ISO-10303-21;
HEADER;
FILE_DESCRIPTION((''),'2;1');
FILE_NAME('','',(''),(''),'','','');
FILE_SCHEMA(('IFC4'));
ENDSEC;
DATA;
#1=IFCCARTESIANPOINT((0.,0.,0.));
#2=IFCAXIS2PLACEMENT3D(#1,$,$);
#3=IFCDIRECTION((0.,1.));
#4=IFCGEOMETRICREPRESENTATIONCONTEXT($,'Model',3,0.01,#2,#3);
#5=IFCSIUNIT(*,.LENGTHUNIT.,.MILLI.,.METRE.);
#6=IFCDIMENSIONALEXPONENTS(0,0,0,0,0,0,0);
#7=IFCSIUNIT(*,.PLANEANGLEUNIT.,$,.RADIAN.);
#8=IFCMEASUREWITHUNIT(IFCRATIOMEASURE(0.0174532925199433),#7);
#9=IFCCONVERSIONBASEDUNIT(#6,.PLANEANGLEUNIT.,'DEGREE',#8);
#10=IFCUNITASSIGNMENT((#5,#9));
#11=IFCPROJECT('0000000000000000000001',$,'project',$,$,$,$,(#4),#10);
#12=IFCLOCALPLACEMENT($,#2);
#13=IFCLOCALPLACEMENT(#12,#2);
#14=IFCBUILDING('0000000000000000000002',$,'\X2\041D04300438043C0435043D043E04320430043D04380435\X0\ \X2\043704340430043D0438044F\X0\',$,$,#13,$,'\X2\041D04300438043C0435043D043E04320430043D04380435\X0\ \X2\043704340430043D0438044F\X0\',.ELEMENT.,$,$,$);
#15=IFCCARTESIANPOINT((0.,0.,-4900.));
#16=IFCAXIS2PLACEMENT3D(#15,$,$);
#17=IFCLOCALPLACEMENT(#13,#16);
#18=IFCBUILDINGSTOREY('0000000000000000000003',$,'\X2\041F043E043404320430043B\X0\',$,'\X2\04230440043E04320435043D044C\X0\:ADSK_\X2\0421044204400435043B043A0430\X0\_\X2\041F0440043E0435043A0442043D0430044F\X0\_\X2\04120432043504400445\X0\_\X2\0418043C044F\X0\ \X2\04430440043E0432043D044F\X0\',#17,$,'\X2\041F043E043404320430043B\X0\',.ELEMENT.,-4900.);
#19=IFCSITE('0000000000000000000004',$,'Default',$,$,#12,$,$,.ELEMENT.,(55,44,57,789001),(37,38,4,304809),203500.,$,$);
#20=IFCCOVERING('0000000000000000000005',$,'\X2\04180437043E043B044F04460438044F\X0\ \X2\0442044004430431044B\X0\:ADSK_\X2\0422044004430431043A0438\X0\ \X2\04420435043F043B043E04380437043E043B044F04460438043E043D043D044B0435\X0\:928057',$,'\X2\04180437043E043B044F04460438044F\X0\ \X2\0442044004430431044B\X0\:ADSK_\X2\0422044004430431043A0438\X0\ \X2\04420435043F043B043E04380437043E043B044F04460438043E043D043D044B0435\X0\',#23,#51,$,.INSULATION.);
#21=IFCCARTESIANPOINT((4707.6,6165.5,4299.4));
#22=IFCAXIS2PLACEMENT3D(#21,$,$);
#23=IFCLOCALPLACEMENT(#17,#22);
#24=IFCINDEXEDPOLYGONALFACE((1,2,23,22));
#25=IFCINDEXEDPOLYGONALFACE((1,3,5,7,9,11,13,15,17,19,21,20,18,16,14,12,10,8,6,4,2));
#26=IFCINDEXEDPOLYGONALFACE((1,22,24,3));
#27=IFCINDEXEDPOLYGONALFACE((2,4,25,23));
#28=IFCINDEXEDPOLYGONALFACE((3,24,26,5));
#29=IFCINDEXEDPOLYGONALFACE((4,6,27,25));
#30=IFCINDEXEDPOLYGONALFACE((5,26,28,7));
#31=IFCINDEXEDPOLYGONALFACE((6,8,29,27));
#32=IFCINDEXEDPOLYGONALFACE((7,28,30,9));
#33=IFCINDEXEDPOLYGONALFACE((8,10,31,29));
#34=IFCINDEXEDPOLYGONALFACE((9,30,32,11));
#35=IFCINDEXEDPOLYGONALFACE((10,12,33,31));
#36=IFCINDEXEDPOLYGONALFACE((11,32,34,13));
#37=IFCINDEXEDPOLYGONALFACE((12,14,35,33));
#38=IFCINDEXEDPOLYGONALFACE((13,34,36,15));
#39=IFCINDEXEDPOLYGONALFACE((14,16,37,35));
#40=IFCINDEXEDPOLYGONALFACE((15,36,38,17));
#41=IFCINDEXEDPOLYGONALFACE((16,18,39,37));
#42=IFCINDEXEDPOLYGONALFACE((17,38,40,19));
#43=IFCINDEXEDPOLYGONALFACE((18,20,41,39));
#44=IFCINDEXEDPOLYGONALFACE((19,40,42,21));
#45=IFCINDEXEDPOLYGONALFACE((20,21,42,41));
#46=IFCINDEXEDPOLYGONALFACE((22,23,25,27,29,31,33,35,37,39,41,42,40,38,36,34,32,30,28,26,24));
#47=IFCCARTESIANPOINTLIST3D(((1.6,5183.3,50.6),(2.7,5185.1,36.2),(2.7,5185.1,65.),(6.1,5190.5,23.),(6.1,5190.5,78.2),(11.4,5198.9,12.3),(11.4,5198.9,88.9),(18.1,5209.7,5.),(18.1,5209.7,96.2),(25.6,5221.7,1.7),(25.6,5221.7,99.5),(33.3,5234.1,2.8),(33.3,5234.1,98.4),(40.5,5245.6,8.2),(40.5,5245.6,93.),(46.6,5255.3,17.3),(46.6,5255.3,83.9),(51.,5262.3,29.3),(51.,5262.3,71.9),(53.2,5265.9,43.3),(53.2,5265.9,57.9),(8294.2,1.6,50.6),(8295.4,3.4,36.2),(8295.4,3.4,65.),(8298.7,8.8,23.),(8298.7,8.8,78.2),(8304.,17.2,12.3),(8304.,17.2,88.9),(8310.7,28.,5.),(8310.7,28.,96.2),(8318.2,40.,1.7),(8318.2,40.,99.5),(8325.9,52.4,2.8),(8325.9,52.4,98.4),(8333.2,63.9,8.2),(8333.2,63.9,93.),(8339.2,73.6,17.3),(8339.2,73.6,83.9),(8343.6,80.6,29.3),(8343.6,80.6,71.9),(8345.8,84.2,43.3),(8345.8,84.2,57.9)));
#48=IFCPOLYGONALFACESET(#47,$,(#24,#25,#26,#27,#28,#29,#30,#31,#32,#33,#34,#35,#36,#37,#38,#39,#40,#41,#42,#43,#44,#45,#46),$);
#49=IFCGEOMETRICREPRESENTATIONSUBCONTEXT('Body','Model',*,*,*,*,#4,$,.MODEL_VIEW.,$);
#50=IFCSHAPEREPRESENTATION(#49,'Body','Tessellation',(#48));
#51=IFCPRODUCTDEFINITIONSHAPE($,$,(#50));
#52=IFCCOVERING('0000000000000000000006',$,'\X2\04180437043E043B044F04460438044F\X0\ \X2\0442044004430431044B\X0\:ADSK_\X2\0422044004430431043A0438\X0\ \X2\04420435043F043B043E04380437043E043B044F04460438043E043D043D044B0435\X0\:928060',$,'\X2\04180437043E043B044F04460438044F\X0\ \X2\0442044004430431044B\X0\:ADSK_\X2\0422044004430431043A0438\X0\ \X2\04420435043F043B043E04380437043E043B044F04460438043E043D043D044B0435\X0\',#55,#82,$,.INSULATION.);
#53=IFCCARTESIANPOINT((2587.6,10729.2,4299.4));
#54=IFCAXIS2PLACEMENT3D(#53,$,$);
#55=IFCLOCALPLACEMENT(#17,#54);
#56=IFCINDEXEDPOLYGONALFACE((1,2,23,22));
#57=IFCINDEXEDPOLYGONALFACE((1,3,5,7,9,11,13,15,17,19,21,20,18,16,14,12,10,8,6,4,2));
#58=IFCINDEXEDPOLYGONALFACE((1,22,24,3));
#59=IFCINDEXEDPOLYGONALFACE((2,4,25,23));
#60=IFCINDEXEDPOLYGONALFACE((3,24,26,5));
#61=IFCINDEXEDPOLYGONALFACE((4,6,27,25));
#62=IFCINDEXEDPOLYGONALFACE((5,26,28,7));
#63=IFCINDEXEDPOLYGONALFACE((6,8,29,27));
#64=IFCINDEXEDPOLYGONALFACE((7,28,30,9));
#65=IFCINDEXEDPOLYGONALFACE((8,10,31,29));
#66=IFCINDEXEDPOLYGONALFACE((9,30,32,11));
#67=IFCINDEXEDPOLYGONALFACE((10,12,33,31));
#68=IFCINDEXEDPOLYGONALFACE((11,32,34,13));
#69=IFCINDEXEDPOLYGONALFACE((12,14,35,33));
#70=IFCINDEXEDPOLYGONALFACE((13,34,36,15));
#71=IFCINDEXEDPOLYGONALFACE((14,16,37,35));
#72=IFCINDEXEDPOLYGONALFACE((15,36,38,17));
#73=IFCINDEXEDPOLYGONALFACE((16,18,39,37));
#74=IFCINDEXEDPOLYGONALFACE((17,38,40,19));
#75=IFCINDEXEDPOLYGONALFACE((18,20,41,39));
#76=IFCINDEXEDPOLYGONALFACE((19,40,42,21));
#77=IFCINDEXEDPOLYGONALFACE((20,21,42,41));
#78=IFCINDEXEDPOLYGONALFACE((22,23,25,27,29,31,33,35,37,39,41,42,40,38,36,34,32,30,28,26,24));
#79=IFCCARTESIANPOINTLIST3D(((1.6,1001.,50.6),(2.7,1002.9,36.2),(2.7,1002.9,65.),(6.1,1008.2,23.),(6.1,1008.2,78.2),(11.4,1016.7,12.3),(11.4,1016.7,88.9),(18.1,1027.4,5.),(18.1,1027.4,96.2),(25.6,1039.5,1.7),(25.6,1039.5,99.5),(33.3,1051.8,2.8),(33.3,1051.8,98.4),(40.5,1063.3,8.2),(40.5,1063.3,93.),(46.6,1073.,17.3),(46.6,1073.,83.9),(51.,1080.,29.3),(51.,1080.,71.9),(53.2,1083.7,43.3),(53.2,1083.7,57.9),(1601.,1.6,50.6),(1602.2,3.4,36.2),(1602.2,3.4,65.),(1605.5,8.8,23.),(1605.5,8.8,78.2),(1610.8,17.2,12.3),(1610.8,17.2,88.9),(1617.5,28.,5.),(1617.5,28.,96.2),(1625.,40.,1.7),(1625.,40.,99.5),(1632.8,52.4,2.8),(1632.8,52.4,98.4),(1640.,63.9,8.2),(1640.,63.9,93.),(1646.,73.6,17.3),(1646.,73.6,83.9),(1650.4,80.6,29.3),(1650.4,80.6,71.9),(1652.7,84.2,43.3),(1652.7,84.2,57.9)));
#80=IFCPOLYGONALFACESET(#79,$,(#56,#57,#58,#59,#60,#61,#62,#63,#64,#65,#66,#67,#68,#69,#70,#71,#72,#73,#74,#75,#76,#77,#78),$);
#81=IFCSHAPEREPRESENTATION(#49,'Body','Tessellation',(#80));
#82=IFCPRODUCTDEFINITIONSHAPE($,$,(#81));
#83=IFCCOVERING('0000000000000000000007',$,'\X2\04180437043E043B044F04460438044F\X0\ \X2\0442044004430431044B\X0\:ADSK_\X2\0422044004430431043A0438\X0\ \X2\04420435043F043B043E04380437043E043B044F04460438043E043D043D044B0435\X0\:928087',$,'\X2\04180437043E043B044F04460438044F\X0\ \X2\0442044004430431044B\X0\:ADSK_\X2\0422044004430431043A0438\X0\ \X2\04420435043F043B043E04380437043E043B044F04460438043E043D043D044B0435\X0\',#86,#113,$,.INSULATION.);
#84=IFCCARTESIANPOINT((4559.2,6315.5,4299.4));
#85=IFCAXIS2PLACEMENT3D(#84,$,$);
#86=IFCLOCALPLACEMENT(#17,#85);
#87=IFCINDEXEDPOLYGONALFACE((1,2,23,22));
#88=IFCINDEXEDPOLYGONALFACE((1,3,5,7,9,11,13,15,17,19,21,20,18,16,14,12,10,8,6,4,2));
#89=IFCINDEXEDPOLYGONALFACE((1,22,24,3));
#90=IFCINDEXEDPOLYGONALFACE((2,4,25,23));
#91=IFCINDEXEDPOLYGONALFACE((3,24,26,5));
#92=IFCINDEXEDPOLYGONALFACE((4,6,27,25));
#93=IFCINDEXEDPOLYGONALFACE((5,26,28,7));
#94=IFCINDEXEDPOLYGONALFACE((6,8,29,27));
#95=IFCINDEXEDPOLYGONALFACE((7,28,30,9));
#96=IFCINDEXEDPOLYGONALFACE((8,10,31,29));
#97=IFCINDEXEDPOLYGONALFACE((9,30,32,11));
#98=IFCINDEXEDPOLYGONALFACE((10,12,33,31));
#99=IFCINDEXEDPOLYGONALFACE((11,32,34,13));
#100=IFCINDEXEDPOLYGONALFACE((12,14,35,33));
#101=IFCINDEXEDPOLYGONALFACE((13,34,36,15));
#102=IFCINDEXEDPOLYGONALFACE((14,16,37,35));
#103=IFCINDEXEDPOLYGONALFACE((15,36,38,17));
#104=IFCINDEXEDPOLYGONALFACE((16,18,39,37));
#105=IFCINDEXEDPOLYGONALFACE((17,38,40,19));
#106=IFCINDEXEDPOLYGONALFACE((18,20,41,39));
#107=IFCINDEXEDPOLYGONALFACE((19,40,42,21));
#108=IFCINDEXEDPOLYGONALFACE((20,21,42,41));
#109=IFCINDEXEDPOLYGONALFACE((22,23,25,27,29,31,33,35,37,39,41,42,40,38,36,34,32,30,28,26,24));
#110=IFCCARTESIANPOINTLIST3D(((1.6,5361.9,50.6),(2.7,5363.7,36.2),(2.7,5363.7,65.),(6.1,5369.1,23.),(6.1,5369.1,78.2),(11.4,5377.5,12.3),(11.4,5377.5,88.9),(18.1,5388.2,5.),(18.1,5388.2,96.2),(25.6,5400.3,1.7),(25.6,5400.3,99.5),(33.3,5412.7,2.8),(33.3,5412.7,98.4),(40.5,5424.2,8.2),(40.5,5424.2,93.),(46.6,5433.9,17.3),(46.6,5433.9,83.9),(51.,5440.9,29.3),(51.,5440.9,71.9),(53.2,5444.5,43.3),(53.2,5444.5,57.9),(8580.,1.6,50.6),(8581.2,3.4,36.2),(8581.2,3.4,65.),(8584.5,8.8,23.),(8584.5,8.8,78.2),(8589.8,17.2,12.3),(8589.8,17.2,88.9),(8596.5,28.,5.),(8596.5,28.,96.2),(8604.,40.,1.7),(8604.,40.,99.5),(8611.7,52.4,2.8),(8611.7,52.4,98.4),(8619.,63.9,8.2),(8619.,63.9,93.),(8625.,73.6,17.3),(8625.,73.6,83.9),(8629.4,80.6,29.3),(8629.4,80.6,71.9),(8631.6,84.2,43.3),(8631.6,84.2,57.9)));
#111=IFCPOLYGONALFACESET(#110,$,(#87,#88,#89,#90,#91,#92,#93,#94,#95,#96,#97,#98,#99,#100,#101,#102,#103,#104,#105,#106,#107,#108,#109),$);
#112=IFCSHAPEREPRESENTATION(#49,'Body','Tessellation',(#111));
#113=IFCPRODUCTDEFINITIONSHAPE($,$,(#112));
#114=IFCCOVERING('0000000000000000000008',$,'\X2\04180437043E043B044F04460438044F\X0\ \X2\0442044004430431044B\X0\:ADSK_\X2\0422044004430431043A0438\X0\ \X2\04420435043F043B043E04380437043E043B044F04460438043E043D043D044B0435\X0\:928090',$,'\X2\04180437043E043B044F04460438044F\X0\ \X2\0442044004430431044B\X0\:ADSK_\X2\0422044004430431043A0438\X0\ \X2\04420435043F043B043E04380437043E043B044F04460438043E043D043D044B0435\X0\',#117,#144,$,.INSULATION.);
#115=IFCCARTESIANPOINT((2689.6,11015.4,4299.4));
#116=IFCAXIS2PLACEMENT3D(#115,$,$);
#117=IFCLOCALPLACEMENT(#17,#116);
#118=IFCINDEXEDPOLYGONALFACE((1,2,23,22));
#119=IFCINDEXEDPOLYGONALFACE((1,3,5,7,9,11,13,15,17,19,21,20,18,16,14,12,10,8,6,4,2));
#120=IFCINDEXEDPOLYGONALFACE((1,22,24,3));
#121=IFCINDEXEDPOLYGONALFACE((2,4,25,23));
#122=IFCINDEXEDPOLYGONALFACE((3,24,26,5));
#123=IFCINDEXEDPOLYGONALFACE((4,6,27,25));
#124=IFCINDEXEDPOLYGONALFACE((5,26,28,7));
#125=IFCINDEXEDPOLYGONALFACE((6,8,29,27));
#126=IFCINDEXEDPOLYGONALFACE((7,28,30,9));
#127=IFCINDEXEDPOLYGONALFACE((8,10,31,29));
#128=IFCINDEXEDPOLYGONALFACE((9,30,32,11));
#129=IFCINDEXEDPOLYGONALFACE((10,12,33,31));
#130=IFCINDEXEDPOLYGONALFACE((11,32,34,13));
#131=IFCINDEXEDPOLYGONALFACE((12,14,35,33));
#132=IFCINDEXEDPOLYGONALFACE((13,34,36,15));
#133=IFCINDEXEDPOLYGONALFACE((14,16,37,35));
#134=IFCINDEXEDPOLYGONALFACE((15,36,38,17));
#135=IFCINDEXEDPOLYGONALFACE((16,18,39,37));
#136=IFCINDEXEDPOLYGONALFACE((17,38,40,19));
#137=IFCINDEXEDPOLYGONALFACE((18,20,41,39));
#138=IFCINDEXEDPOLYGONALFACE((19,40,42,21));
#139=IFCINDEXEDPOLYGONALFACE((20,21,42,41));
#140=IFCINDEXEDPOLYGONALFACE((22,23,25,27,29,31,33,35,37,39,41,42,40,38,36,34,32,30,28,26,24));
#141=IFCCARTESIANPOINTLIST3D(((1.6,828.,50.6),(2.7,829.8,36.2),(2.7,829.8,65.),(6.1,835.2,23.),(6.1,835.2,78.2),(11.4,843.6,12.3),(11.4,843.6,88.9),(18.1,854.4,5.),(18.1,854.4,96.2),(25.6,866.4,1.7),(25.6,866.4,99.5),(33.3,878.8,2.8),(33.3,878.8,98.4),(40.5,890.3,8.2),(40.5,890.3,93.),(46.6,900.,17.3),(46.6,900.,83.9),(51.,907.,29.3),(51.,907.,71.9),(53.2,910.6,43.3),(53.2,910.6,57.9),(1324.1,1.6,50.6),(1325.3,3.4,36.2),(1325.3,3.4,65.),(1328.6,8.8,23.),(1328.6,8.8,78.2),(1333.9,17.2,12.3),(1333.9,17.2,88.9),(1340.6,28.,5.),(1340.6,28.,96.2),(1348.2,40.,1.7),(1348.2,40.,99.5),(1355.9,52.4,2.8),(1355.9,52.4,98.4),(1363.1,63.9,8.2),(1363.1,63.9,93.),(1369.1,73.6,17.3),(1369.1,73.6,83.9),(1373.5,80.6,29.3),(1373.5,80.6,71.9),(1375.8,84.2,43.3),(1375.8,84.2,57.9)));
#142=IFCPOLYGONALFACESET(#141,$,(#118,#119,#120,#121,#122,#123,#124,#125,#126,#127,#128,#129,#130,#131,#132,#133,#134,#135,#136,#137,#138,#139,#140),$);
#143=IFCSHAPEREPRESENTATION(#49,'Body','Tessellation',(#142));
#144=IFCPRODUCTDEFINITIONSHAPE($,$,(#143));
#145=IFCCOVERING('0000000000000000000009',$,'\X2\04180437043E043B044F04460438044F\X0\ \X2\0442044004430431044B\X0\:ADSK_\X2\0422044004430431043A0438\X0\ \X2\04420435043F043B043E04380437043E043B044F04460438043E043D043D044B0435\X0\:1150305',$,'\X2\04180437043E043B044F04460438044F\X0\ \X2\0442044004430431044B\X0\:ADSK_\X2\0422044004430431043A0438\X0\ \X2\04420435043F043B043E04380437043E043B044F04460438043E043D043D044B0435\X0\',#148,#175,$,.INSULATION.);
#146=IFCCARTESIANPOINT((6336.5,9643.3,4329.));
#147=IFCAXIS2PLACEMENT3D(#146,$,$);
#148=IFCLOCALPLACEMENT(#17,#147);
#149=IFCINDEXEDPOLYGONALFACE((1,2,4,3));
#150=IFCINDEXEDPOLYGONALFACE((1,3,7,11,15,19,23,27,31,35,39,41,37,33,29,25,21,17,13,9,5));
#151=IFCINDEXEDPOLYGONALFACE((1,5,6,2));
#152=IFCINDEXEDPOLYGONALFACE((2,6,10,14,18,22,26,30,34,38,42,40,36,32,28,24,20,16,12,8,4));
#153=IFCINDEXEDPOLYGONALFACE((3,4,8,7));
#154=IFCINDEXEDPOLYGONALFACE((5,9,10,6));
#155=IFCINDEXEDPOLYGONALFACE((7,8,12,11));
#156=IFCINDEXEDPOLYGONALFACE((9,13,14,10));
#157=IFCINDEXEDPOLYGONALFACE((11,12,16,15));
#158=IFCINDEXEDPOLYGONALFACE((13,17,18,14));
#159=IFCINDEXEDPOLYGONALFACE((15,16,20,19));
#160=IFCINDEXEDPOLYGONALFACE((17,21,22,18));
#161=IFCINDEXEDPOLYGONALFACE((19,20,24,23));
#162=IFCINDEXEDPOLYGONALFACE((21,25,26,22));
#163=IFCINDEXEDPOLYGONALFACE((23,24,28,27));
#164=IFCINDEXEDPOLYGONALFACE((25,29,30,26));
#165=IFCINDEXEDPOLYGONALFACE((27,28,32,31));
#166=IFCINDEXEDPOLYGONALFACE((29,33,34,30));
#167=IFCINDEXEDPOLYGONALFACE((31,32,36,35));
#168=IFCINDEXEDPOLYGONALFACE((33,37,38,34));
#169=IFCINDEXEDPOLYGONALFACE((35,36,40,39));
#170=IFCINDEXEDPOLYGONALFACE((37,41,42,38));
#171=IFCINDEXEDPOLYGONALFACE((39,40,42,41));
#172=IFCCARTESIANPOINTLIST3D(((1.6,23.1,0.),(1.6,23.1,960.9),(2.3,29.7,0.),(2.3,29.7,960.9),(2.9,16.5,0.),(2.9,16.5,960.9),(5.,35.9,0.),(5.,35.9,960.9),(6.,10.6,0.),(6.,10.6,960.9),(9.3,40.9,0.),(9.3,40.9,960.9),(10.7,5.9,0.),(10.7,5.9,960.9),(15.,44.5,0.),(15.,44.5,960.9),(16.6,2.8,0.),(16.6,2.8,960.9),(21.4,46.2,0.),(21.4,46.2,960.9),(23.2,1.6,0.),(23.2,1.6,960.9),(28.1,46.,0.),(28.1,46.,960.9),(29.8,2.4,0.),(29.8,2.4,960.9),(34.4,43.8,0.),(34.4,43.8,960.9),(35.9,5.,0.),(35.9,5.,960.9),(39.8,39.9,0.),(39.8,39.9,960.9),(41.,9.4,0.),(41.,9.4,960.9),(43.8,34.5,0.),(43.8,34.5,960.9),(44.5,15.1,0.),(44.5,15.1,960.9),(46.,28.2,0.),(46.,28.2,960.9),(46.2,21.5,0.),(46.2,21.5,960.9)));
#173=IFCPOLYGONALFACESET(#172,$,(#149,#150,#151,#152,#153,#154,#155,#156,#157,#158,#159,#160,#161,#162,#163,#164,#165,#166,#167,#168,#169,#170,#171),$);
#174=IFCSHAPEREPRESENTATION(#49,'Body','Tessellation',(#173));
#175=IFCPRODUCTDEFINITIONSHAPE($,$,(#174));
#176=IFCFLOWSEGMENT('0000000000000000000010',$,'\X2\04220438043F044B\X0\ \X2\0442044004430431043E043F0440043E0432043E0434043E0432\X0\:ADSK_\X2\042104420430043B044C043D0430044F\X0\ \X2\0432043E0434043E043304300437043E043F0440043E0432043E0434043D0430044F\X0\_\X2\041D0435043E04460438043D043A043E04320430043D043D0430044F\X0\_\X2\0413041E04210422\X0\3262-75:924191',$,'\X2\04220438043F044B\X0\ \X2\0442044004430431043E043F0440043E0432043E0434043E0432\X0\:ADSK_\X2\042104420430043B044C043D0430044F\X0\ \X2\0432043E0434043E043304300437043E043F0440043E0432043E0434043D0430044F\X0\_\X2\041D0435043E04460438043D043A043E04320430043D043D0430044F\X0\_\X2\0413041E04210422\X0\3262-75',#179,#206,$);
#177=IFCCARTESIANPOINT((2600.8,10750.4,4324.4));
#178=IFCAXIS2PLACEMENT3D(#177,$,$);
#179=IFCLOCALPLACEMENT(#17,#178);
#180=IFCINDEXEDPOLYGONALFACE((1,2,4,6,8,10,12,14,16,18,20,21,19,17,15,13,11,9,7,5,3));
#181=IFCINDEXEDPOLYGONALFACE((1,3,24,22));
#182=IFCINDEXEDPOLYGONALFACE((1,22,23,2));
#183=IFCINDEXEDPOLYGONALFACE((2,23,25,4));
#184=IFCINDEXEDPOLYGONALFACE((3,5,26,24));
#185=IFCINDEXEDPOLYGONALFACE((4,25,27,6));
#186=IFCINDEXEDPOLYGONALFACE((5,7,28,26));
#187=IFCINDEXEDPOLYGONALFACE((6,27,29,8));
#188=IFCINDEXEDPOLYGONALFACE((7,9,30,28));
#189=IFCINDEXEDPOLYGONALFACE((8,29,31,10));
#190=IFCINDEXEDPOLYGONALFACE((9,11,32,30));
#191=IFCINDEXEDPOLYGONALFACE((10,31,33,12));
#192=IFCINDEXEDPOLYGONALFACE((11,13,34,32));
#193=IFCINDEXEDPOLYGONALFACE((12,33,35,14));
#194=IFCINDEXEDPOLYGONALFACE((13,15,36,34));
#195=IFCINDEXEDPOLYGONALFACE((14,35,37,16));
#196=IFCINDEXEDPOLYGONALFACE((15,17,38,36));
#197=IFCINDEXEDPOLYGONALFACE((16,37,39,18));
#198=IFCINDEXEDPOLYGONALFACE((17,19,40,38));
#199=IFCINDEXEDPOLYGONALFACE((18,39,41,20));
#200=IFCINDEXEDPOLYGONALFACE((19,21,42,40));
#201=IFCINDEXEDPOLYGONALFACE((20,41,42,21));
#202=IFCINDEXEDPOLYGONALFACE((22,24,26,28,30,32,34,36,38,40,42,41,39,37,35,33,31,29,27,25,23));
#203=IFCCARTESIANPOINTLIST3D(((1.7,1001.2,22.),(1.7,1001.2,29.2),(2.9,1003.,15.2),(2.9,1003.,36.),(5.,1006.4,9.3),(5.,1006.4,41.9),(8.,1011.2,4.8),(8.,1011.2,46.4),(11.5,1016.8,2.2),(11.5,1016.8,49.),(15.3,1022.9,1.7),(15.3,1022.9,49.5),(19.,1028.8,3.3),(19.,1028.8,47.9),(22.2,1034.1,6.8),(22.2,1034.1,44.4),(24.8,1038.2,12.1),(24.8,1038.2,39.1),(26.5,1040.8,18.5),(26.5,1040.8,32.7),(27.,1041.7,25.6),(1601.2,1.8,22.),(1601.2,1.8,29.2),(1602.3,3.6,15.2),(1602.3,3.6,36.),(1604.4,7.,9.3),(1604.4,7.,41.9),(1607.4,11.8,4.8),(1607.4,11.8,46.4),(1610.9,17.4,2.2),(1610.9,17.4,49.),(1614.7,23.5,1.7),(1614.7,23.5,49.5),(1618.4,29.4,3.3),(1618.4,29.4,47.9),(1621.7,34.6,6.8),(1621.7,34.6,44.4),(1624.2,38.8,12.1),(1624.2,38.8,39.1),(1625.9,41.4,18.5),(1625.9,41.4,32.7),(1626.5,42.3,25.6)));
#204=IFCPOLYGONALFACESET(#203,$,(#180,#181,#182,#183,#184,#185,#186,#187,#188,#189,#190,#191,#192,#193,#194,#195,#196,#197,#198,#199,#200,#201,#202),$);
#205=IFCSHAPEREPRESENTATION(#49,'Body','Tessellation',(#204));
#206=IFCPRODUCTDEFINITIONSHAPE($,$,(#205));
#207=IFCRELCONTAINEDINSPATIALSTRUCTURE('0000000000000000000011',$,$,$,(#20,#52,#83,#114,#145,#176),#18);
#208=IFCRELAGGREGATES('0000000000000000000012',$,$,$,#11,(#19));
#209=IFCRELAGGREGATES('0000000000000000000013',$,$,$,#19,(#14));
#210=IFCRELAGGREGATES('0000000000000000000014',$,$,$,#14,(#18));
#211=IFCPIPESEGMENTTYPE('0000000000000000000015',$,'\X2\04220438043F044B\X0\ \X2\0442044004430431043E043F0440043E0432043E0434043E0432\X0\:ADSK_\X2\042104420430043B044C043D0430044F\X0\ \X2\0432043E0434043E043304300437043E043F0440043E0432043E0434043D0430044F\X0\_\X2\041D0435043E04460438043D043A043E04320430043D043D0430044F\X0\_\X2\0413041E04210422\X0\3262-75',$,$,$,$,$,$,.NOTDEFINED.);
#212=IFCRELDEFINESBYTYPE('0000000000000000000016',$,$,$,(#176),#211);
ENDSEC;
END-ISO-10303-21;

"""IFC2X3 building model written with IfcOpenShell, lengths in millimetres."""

from ifc_helpers import new_model, entity, si_unit, converted_unit, direction, frame, origin, origin_2d_with_axis, place, context, subcontext, project, spatial, circle, extrude, type_object, element, save


model = new_model("IFC2X3")

# Units and contexts
model_context = context("Model", 3, precision=0.01, world=origin(), true_north=direction((0.0, 1.0)))
body_context = subcontext(model_context, "Body", "Model", "MODEL_VIEW")
ifc_project = project(units=[si_unit("LENGTHUNIT", "METRE", prefix="MILLI"), converted_unit("PLANEANGLEUNIT", "DEGREE", entity("IfcRatioMeasure", 0.0174532925199433), si_unit("PLANEANGLEUNIT", "RADIAN"), dimensions=[0, 0, 0, 0, 0, 0, 0])], contexts=[model_context])

# Site, building, storey
site_placement = place(None, origin())
site = spatial("IfcSite", under=ifc_project, at=site_placement, Name="Default", CompositionType="ELEMENT", RefLatitude=(55, 44, 57, 789001), RefLongitude=(37, 38, 4, 304809), RefElevation=203500.0)
building_placement = place(site_placement, origin())
building = spatial("IfcBuilding", under=site, at=building_placement, Name="Наименование здания", LongName="Наименование здания", CompositionType="ELEMENT")
storey_placement = place(building_placement, frame((0.0, 0.0, -4900.0)))
storey = spatial("IfcBuildingStorey", under=building, at=storey_placement, Name="Подвал", ObjectType="Уровень:ADSK_Стрелка_Проектная_Вверх_Имя уровня", LongName="Подвал", CompositionType="ELEMENT", Elevation=-4900.0)

# Coverings
covering_1_placement = place(storey_placement, frame((4707.6, 6165.5, 4299.4)))
element("IfcCovering", 1, at=covering_1_placement, inside=storey, Name="Изоляция трубы:ADSK_Трубки теплоизоляционные:928057", ObjectType="Изоляция трубы:ADSK_Трубки теплоизоляционные", PredefinedType="INSULATION", context=body_context, shape_type="SweptSolid", body=[
    extrude(circle(Radius=49.0, at=origin_2d_with_axis()), frame((27.6, 5224.9, 50.6), z_axis=(0.848053, -0.529912, 0.0), x_axis=(-0.529912, -0.848053, 0.0)), (0.0, 0.0, 1.0), 9778.4),
])
covering_2_placement = place(storey_placement, frame((2587.6, 10729.2, 4299.4)))
element("IfcCovering", 2, at=covering_2_placement, inside=storey, Name="Изоляция трубы:ADSK_Трубки теплоизоляционные:928060", ObjectType="Изоляция трубы:ADSK_Трубки теплоизоляционные", PredefinedType="INSULATION", context=body_context, shape_type="SweptSolid", body=[
    extrude(circle(Radius=49.0, at=origin_2d_with_axis()), frame((27.6, 1042.6, 50.6), z_axis=(0.848053, -0.529912, 0.0), x_axis=(-0.529912, -0.848053, 0.0)), (0.0, 0.0, 1.0), 1886.0),
])
covering_3_placement = place(storey_placement, frame((4559.2, 6315.5, 4299.4)))
element("IfcCovering", 3, at=covering_3_placement, inside=storey, Name="Изоляция трубы:ADSK_Трубки теплоизоляционные:928087", ObjectType="Изоляция трубы:ADSK_Трубки теплоизоляционные", PredefinedType="INSULATION", context=body_context, shape_type="SweptSolid", body=[
    extrude(circle(Radius=49.0, at=origin_2d_with_axis()), frame((27.6, 5403.4, 50.6), z_axis=(0.848053, -0.529912, 0.0), x_axis=(-0.529912, -0.848053, 0.0)), (0.0, 0.0, 1.0), 10115.4),
])
covering_4_placement = place(storey_placement, frame((2689.6, 11015.4, 4299.4)))
element("IfcCovering", 4, at=covering_4_placement, inside=storey, Name="Изоляция трубы:ADSK_Трубки теплоизоляционные:928090", ObjectType="Изоляция трубы:ADSK_Трубки теплоизоляционные", PredefinedType="INSULATION", context=body_context, shape_type="SweptSolid", body=[
    extrude(circle(Radius=49.0, at=origin_2d_with_axis()), frame((27.6, 869.5, 50.6), z_axis=(0.848053, -0.529912, 0.0), x_axis=(-0.529912, -0.848053, 0.0)), (0.0, 0.0, 1.0), 1559.5),
])
covering_5_placement = place(storey_placement, frame((6336.5, 9643.3, 4329.0)))
element("IfcCovering", 5, at=covering_5_placement, inside=storey, Name="Изоляция трубы:ADSK_Трубки теплоизоляционные:1150305", ObjectType="Изоляция трубы:ADSK_Трубки теплоизоляционные", PredefinedType="INSULATION", context=body_context, shape_type="SweptSolid", body=[
    extrude(circle(Radius=22.4, at=origin_2d_with_axis()), frame((24.0, 24.0, 0.0), z_axis=(0.000001, 0.000001, 1.0), x_axis=(-0.848053, 0.529912, 0.0)), (0.0, 0.0, 1.0), 960.9),
])

# Flow segment
pipe_segment_type = type_object("IfcPipeSegmentType", Name="Типы трубопроводов:ADSK_Стальная водогазопроводная_Неоцинкованная_ГОСТ3262-75", PredefinedType="NOTDEFINED")
flow_segment_1_placement = place(storey_placement, frame((2600.8, 10750.4, 4324.4)))
element("IfcFlowSegment", 6, at=flow_segment_1_placement, inside=storey, type_object=pipe_segment_type, Name="Типы трубопроводов:ADSK_Стальная водогазопроводная_Неоцинкованная_ГОСТ3262-75:924191", ObjectType="Типы трубопроводов:ADSK_Стальная водогазопроводная_Неоцинкованная_ГОСТ3262-75", context=body_context, shape_type="SweptSolid", body=[
    extrude(circle(Radius=24.0, at=origin_2d_with_axis()), frame((14.3, 1021.4, 25.6), z_axis=(0.848053, -0.529912, 0.0), x_axis=(0.529912, 0.848053, 0.0)), (0.0, 0.0, 1.0), 1886.0),
])

save(model, "model.ifc")
